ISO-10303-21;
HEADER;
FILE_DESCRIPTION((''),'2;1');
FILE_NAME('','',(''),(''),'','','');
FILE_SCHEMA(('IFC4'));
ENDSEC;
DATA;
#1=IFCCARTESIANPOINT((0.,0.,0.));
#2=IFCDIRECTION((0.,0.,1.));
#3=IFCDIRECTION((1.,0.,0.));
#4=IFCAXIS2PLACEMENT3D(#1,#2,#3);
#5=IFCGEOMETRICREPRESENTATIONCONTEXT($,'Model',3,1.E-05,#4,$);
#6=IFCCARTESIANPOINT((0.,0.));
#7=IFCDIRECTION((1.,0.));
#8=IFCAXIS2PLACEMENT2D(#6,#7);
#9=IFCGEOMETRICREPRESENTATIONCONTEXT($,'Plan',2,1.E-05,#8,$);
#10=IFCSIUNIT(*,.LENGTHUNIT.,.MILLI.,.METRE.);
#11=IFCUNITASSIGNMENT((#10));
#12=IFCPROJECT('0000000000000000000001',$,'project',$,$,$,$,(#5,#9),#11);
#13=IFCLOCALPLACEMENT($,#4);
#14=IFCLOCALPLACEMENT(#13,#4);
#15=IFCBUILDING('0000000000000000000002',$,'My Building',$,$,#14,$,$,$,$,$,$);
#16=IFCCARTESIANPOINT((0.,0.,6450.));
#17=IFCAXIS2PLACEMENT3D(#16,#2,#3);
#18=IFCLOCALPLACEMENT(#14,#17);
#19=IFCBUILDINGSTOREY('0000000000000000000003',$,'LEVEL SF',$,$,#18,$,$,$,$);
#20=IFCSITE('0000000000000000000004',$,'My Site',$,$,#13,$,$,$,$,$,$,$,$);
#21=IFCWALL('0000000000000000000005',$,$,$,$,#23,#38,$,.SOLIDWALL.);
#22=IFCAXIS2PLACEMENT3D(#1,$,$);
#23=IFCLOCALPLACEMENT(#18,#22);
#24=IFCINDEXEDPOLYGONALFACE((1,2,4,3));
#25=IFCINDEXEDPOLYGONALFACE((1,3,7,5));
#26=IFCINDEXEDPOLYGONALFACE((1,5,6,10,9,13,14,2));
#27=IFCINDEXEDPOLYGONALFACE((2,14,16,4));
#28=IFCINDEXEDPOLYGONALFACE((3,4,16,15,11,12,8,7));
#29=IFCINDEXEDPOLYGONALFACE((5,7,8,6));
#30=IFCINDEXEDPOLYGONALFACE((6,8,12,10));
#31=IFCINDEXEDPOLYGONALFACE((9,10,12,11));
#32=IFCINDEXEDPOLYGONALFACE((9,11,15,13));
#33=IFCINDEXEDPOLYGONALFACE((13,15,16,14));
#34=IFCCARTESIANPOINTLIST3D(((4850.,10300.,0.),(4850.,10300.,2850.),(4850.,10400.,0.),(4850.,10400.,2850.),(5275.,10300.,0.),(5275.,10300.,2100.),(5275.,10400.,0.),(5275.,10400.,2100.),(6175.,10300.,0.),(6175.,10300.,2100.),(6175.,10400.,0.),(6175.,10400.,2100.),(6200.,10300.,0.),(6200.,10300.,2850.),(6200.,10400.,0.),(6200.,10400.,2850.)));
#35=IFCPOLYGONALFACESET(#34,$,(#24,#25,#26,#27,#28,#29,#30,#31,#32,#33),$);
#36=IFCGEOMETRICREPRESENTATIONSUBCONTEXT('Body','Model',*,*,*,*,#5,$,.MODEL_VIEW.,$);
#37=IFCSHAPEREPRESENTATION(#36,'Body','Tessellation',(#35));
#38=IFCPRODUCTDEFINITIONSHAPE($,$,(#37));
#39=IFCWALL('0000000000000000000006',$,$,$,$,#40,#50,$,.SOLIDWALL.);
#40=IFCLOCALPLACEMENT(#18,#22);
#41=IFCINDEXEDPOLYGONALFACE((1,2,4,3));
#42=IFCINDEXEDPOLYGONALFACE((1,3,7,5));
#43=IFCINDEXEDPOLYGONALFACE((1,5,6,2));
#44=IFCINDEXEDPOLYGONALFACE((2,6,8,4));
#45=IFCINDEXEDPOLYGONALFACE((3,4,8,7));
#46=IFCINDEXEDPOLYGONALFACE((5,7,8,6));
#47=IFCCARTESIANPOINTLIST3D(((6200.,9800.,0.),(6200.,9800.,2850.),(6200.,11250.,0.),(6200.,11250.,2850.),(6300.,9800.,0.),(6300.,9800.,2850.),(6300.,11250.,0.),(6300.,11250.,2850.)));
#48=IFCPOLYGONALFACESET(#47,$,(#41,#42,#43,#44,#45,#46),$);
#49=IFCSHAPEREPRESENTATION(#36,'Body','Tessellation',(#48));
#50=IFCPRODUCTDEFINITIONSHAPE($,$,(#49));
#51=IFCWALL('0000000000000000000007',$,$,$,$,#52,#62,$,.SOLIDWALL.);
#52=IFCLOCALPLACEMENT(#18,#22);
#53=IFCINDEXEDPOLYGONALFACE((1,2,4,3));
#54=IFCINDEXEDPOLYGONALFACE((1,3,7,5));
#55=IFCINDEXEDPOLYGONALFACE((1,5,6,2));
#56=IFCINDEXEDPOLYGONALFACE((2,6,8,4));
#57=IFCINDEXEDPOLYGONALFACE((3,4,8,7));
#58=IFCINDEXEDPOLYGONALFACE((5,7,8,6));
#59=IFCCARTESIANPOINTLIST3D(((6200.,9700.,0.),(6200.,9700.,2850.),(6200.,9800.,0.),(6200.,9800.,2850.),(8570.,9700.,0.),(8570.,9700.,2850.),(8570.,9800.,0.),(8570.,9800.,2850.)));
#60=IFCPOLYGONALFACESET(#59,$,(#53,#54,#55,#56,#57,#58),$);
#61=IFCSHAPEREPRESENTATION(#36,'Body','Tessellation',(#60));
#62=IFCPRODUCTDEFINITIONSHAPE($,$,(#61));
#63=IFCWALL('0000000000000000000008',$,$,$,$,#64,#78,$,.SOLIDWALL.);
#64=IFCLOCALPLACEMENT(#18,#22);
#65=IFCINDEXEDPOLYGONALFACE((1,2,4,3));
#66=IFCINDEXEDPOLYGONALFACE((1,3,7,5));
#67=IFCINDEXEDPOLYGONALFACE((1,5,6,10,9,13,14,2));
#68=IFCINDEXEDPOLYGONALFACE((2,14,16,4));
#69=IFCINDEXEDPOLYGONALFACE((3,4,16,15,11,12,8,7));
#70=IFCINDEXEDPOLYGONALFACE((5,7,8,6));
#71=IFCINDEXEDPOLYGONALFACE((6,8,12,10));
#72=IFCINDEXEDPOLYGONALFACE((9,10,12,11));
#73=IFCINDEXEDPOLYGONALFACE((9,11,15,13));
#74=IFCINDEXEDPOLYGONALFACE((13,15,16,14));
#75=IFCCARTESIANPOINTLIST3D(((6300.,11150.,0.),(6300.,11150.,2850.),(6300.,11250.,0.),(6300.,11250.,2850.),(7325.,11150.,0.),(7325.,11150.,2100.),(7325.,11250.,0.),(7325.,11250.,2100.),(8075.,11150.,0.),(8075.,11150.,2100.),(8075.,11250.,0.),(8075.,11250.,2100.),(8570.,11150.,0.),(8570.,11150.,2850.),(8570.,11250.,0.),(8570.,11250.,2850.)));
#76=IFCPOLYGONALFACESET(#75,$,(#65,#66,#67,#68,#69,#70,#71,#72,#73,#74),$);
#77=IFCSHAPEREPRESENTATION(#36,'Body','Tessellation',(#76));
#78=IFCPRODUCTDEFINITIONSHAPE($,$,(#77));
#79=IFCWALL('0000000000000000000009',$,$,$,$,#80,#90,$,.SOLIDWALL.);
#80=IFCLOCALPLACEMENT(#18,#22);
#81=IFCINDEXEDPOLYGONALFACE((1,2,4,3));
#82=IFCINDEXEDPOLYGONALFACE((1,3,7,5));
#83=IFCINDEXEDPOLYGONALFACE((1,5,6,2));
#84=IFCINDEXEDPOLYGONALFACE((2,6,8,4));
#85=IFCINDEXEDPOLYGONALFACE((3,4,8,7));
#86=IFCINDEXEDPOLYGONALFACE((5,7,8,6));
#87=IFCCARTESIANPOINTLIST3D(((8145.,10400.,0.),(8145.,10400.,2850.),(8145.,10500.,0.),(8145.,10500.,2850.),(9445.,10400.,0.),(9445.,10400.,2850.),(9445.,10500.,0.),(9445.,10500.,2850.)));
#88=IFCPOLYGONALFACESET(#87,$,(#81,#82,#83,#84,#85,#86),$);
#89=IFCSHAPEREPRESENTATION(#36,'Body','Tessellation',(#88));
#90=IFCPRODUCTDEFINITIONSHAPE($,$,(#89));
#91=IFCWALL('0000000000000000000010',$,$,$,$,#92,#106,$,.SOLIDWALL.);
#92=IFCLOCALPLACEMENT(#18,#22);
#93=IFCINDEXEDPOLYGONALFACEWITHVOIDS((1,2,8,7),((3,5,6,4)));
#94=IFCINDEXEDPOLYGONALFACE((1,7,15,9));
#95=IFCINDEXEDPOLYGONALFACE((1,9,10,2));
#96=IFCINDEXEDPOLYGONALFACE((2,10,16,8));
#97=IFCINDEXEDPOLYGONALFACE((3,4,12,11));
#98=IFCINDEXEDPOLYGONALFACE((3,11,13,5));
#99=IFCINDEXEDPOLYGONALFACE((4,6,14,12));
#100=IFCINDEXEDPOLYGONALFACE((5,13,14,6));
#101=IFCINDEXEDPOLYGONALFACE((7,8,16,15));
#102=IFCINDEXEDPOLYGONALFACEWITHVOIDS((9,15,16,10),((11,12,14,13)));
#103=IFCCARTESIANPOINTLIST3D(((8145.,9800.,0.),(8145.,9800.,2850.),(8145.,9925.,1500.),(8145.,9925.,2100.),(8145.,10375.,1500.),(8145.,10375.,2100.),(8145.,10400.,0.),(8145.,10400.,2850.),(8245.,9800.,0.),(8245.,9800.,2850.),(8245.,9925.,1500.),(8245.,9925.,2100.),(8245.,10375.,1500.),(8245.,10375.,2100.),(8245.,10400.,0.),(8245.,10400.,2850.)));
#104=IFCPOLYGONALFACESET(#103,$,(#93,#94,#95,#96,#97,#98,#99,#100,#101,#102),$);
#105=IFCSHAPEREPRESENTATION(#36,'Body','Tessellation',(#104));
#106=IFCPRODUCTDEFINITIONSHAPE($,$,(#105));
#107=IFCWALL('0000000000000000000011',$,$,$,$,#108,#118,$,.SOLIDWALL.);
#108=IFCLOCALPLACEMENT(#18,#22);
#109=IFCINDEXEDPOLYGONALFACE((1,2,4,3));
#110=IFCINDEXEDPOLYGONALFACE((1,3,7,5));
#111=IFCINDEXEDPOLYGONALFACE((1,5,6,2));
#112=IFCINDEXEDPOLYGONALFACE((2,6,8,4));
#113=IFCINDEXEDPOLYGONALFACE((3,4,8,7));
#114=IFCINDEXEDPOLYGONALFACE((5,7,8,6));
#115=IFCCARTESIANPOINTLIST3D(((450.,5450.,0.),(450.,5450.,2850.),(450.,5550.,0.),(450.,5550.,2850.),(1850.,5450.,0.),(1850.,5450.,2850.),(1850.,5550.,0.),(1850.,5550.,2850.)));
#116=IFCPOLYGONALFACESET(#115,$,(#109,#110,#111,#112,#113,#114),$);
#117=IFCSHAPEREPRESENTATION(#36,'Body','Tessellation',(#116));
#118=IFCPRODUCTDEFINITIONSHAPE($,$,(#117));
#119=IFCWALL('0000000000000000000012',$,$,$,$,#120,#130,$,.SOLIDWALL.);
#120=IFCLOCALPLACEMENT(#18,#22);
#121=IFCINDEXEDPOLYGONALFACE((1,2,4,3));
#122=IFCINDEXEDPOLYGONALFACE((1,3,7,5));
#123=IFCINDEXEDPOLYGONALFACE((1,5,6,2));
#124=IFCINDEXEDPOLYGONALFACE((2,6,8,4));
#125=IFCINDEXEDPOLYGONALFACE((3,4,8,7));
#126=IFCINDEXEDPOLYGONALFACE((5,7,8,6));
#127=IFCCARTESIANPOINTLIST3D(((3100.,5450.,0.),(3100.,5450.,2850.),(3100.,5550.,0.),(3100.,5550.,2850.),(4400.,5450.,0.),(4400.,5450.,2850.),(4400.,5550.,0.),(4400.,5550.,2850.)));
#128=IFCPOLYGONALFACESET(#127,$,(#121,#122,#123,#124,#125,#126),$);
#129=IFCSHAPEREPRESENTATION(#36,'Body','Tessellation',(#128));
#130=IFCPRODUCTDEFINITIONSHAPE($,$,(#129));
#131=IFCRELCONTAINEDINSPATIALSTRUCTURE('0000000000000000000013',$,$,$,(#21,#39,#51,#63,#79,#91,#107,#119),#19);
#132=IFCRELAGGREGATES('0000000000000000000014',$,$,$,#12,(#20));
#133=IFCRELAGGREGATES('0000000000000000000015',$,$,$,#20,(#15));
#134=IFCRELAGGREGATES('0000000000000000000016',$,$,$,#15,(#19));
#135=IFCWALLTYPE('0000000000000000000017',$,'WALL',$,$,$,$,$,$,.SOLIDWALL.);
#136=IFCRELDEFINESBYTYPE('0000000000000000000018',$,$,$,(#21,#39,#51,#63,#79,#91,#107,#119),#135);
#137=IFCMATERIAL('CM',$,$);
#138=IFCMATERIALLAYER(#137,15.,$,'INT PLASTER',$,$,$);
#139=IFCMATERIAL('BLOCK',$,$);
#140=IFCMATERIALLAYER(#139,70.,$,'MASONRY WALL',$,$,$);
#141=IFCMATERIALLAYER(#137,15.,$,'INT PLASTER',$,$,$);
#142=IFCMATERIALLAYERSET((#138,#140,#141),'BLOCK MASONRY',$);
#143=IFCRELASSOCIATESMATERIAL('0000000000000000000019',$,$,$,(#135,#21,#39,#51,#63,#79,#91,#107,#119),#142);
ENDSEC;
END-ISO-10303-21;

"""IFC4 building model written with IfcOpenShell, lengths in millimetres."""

from ifc_helpers import new_model, si_unit, frame, origin_with_axes, origin_2d_with_axis, place, context, subcontext, project, spatial, indexed_curve, outline, extrude, material, layer, layer_set, layer_usage, type_object, element, save


model = new_model("IFC4")

# Units and contexts
model_context = context("Model", 3, precision=1e-05, world=origin_with_axes())
plan_context = context("Plan", 2, precision=1e-05, world=origin_2d_with_axis())
body_context = subcontext(model_context, "Body", "Model", "MODEL_VIEW")
ifc_project = project(units=[si_unit("LENGTHUNIT", "METRE", prefix="MILLI")], contexts=[model_context, plan_context])

# Site, building, storey
site_placement = place(None, origin_with_axes())
site = spatial("IfcSite", under=ifc_project, at=site_placement, Name="My Site")
building_placement = place(site_placement, origin_with_axes())
building = spatial("IfcBuilding", under=site, at=building_placement, Name="My Building")
storey_placement = place(building_placement, frame((0.0, 0.0, 6450.0), z_axis=(0.0, 0.0, 1.0), x_axis=(1.0, 0.0, 0.0)))
storey = spatial("IfcBuildingStorey", under=building, at=storey_placement, Name="LEVEL SF")

# Shared definitions
ifc_material_1 = material(Name="CM")
ifc_layer_1 = layer(ifc_material_1, 15.0, Name="INT PLASTER")
ifc_material_2 = material(Name="BLOCK")
ifc_layer_2 = layer(ifc_material_2, 70.0, Name="MASONRY WALL")
ifc_layer_3 = layer(ifc_material_1, 15.0, Name="INT PLASTER")
ifc_layer_set = layer_set([ifc_layer_1, ifc_layer_2, ifc_layer_3], Name="BLOCK MASONRY")
wall_type = type_object("IfcWallType", Name="WALL", PredefinedType="SOLIDWALL", material=ifc_layer_set)

# Wall, opening
ifc_layer_usage_1 = layer_usage(ifc_layer_set, "AXIS2", "POSITIVE", 0.0)
wall_1_placement = place(storey_placement, frame((4850.0, 10400.0, 0.0), z_axis=(0.0, 0.0, 1.0), x_axis=(0.0, -1.0, 0.0)))
wall_1 = element("IfcWall", 1, at=wall_1_placement, inside=storey, type_object=wall_type, material=ifc_layer_usage_1, PredefinedType="SOLIDWALL", context=body_context, shape_type="SweptSolid", body=[
    extrude(outline(indexed_curve([(0.0, 0.0), (0.0, 1350.0), (100.0, 1350.0), (100.0, 0.0), (0.0, 0.0)], self_intersect=False)), origin_with_axes(), (0.0, 0.0, 1.0), 2850.0),
])
opening_1_placement = place(wall_1_placement, frame((100.0, 425.0, 0.0), z_axis=(0.0, 0.0, 1.0), x_axis=(0.0, 1.0, 0.0)))
element("IfcOpeningElement", 2, at=opening_1_placement, cuts=wall_1, PredefinedType="OPENING", context=body_context, shape_type="SweptSolid", body=[
    extrude(outline(indexed_curve([(0.0, 0.0), (0.0, 400.0), (900.0, 400.0), (900.0, 0.0), (0.0, 0.0)], self_intersect=False)), frame((0.0, -100.0, 0.0), z_axis=(0.0, 0.0, 1.0), x_axis=(1.0, 0.0, 0.0)), (0.0, 0.0, 1.0), 2100.0),
])

# Walls
ifc_layer_usage_2 = layer_usage(ifc_layer_set, "AXIS2", "POSITIVE", 0.0)
wall_2_placement = place(storey_placement, frame((6300.0, 9800.0, 0.0), z_axis=(0.0, 0.0, 1.0), x_axis=(0.0, 1.0, 0.0)))
element("IfcWall", 3, at=wall_2_placement, inside=storey, type_object=wall_type, material=ifc_layer_usage_2, PredefinedType="SOLIDWALL", context=body_context, shape_type="SweptSolid", body=[
    extrude(outline(indexed_curve([(0.0, 0.0), (0.0, 100.0), (1450.0, 100.0), (1450.0, 0.0), (0.0, 0.0)], self_intersect=False)), origin_with_axes(), (0.0, 0.0, 1.0), 2850.0),
])
ifc_layer_usage_3 = layer_usage(ifc_layer_set, "AXIS2", "POSITIVE", 0.0)
wall_3_placement = place(storey_placement, frame((6200.0, 9800.0, 0.0), z_axis=(0.0, 0.0, 1.0), x_axis=(0.0, -1.0, 0.0)))
element("IfcWall", 4, at=wall_3_placement, inside=storey, type_object=wall_type, material=ifc_layer_usage_3, PredefinedType="SOLIDWALL", context=body_context, shape_type="SweptSolid", body=[
    extrude(outline(indexed_curve([(0.0, 0.0), (0.0, 2370.0), (100.0, 2370.0), (100.0, 0.0), (0.0, 0.0)], self_intersect=False)), origin_with_axes(), (0.0, 0.0, 1.0), 2850.0),
])

# Wall, opening
ifc_layer_usage_4 = layer_usage(ifc_layer_set, "AXIS2", "POSITIVE", 0.0)
wall_4_placement = place(storey_placement, frame((6300.0, 11250.0, 0.0), z_axis=(0.0, 0.0, 1.0), x_axis=(0.0, -1.0, 0.0)))
wall_4 = element("IfcWall", 5, at=wall_4_placement, inside=storey, type_object=wall_type, material=ifc_layer_usage_4, PredefinedType="SOLIDWALL", context=body_context, shape_type="SweptSolid", body=[
    extrude(outline(indexed_curve([(0.0, 0.0), (0.0, 2270.0), (100.0, 2270.0), (100.0, 0.0), (0.0, 0.0)], self_intersect=False)), origin_with_axes(), (0.0, 0.0, 1.0), 2850.0),
])
opening_2_placement = place(wall_4_placement, frame((0.0, 1775.0, 0.0), z_axis=(0.0, 0.0, 1.0), x_axis=(0.0, -1.0, 0.0)))
element("IfcOpeningElement", 6, at=opening_2_placement, cuts=wall_4, PredefinedType="OPENING", context=body_context, shape_type="SweptSolid", body=[
    extrude(outline(indexed_curve([(0.0, 0.0), (0.0, 400.0), (750.0, 400.0), (750.0, 0.0), (0.0, 0.0)], self_intersect=False)), frame((0.0, -100.0, 0.0), z_axis=(0.0, 0.0, 1.0), x_axis=(1.0, 0.0, 0.0)), (0.0, 0.0, 1.0), 2100.0),
])

# Wall
ifc_layer_usage_5 = layer_usage(ifc_layer_set, "AXIS2", "POSITIVE", 0.0)
wall_5_placement = place(storey_placement, frame((8145.0, 10500.0, 0.0), z_axis=(0.0, 0.0, 1.0), x_axis=(0.0, -1.0, 0.0)))
element("IfcWall", 7, at=wall_5_placement, inside=storey, type_object=wall_type, material=ifc_layer_usage_5, PredefinedType="SOLIDWALL", context=body_context, shape_type="SweptSolid", body=[
    extrude(outline(indexed_curve([(0.0, 0.0), (0.0, 1300.0), (100.0, 1300.0), (100.0, 0.0), (0.0, 0.0)], self_intersect=False)), origin_with_axes(), (0.0, 0.0, 1.0), 2850.0),
])

# Wall, opening
ifc_layer_usage_6 = layer_usage(ifc_layer_set, "AXIS2", "POSITIVE", 0.0)
wall_6_placement = place(storey_placement, frame((8245.0, 9800.0, 0.0), z_axis=(0.0, 0.0, 1.0), x_axis=(0.0, 1.0, 0.0)))
wall_6 = element("IfcWall", 8, at=wall_6_placement, inside=storey, type_object=wall_type, material=ifc_layer_usage_6, PredefinedType="SOLIDWALL", context=body_context, shape_type="SweptSolid", body=[
    extrude(outline(indexed_curve([(0.0, 0.0), (0.0, 100.0), (600.0, 100.0), (600.0, 0.0), (0.0, 0.0)], self_intersect=False)), origin_with_axes(), (0.0, 0.0, 1.0), 2850.0),
])
opening_3_placement = place(wall_6_placement, frame((575.0, 100.0, 1500.0), z_axis=(0.0, 0.0, 1.0), x_axis=(-1.0, 0.0, 0.0)))
element("IfcOpeningElement", 9, at=opening_3_placement, cuts=wall_6, PredefinedType="OPENING", context=body_context, shape_type="SweptSolid", body=[
    extrude(outline(indexed_curve([(0.0, 0.0), (0.0, 400.0), (450.0, 400.0), (450.0, 0.0), (0.0, 0.0)], self_intersect=False)), frame((0.0, -100.0, 0.0), z_axis=(0.0, 0.0, 1.0), x_axis=(1.0, 0.0, 0.0)), (0.0, 0.0, 1.0), 600.0),
])

# Walls
ifc_layer_usage_7 = layer_usage(ifc_layer_set, "AXIS2", "POSITIVE", 0.0)
wall_7_placement = place(storey_placement, frame((450.0, 5550.0, 0.0), z_axis=(0.0, 0.0, 1.0), x_axis=(0.0, -1.0, 0.0)))
element("IfcWall", 10, at=wall_7_placement, inside=storey, type_object=wall_type, material=ifc_layer_usage_7, PredefinedType="SOLIDWALL", context=body_context, shape_type="SweptSolid", body=[
    extrude(outline(indexed_curve([(0.0, 0.0), (0.0, 1400.0), (100.0, 1400.0), (100.0, 0.0), (0.0, 0.0)], self_intersect=False)), origin_with_axes(), (0.0, 0.0, 1.0), 2850.0),
])
ifc_layer_usage_8 = layer_usage(ifc_layer_set, "AXIS2", "POSITIVE", 0.0)
wall_8_placement = place(storey_placement, frame((3100.0, 5550.0, 0.0), z_axis=(0.0, 0.0, 1.0), x_axis=(0.0, -1.0, 0.0)))
element("IfcWall", 11, at=wall_8_placement, inside=storey, type_object=wall_type, material=ifc_layer_usage_8, PredefinedType="SOLIDWALL", context=body_context, shape_type="SweptSolid", body=[
    extrude(outline(indexed_curve([(0.0, 0.0), (0.0, 1300.0), (100.0, 1300.0), (100.0, 0.0), (0.0, 0.0)], self_intersect=False)), origin_with_axes(), (0.0, 0.0, 1.0), 2850.0),
])

save(model, "model.ifc")
